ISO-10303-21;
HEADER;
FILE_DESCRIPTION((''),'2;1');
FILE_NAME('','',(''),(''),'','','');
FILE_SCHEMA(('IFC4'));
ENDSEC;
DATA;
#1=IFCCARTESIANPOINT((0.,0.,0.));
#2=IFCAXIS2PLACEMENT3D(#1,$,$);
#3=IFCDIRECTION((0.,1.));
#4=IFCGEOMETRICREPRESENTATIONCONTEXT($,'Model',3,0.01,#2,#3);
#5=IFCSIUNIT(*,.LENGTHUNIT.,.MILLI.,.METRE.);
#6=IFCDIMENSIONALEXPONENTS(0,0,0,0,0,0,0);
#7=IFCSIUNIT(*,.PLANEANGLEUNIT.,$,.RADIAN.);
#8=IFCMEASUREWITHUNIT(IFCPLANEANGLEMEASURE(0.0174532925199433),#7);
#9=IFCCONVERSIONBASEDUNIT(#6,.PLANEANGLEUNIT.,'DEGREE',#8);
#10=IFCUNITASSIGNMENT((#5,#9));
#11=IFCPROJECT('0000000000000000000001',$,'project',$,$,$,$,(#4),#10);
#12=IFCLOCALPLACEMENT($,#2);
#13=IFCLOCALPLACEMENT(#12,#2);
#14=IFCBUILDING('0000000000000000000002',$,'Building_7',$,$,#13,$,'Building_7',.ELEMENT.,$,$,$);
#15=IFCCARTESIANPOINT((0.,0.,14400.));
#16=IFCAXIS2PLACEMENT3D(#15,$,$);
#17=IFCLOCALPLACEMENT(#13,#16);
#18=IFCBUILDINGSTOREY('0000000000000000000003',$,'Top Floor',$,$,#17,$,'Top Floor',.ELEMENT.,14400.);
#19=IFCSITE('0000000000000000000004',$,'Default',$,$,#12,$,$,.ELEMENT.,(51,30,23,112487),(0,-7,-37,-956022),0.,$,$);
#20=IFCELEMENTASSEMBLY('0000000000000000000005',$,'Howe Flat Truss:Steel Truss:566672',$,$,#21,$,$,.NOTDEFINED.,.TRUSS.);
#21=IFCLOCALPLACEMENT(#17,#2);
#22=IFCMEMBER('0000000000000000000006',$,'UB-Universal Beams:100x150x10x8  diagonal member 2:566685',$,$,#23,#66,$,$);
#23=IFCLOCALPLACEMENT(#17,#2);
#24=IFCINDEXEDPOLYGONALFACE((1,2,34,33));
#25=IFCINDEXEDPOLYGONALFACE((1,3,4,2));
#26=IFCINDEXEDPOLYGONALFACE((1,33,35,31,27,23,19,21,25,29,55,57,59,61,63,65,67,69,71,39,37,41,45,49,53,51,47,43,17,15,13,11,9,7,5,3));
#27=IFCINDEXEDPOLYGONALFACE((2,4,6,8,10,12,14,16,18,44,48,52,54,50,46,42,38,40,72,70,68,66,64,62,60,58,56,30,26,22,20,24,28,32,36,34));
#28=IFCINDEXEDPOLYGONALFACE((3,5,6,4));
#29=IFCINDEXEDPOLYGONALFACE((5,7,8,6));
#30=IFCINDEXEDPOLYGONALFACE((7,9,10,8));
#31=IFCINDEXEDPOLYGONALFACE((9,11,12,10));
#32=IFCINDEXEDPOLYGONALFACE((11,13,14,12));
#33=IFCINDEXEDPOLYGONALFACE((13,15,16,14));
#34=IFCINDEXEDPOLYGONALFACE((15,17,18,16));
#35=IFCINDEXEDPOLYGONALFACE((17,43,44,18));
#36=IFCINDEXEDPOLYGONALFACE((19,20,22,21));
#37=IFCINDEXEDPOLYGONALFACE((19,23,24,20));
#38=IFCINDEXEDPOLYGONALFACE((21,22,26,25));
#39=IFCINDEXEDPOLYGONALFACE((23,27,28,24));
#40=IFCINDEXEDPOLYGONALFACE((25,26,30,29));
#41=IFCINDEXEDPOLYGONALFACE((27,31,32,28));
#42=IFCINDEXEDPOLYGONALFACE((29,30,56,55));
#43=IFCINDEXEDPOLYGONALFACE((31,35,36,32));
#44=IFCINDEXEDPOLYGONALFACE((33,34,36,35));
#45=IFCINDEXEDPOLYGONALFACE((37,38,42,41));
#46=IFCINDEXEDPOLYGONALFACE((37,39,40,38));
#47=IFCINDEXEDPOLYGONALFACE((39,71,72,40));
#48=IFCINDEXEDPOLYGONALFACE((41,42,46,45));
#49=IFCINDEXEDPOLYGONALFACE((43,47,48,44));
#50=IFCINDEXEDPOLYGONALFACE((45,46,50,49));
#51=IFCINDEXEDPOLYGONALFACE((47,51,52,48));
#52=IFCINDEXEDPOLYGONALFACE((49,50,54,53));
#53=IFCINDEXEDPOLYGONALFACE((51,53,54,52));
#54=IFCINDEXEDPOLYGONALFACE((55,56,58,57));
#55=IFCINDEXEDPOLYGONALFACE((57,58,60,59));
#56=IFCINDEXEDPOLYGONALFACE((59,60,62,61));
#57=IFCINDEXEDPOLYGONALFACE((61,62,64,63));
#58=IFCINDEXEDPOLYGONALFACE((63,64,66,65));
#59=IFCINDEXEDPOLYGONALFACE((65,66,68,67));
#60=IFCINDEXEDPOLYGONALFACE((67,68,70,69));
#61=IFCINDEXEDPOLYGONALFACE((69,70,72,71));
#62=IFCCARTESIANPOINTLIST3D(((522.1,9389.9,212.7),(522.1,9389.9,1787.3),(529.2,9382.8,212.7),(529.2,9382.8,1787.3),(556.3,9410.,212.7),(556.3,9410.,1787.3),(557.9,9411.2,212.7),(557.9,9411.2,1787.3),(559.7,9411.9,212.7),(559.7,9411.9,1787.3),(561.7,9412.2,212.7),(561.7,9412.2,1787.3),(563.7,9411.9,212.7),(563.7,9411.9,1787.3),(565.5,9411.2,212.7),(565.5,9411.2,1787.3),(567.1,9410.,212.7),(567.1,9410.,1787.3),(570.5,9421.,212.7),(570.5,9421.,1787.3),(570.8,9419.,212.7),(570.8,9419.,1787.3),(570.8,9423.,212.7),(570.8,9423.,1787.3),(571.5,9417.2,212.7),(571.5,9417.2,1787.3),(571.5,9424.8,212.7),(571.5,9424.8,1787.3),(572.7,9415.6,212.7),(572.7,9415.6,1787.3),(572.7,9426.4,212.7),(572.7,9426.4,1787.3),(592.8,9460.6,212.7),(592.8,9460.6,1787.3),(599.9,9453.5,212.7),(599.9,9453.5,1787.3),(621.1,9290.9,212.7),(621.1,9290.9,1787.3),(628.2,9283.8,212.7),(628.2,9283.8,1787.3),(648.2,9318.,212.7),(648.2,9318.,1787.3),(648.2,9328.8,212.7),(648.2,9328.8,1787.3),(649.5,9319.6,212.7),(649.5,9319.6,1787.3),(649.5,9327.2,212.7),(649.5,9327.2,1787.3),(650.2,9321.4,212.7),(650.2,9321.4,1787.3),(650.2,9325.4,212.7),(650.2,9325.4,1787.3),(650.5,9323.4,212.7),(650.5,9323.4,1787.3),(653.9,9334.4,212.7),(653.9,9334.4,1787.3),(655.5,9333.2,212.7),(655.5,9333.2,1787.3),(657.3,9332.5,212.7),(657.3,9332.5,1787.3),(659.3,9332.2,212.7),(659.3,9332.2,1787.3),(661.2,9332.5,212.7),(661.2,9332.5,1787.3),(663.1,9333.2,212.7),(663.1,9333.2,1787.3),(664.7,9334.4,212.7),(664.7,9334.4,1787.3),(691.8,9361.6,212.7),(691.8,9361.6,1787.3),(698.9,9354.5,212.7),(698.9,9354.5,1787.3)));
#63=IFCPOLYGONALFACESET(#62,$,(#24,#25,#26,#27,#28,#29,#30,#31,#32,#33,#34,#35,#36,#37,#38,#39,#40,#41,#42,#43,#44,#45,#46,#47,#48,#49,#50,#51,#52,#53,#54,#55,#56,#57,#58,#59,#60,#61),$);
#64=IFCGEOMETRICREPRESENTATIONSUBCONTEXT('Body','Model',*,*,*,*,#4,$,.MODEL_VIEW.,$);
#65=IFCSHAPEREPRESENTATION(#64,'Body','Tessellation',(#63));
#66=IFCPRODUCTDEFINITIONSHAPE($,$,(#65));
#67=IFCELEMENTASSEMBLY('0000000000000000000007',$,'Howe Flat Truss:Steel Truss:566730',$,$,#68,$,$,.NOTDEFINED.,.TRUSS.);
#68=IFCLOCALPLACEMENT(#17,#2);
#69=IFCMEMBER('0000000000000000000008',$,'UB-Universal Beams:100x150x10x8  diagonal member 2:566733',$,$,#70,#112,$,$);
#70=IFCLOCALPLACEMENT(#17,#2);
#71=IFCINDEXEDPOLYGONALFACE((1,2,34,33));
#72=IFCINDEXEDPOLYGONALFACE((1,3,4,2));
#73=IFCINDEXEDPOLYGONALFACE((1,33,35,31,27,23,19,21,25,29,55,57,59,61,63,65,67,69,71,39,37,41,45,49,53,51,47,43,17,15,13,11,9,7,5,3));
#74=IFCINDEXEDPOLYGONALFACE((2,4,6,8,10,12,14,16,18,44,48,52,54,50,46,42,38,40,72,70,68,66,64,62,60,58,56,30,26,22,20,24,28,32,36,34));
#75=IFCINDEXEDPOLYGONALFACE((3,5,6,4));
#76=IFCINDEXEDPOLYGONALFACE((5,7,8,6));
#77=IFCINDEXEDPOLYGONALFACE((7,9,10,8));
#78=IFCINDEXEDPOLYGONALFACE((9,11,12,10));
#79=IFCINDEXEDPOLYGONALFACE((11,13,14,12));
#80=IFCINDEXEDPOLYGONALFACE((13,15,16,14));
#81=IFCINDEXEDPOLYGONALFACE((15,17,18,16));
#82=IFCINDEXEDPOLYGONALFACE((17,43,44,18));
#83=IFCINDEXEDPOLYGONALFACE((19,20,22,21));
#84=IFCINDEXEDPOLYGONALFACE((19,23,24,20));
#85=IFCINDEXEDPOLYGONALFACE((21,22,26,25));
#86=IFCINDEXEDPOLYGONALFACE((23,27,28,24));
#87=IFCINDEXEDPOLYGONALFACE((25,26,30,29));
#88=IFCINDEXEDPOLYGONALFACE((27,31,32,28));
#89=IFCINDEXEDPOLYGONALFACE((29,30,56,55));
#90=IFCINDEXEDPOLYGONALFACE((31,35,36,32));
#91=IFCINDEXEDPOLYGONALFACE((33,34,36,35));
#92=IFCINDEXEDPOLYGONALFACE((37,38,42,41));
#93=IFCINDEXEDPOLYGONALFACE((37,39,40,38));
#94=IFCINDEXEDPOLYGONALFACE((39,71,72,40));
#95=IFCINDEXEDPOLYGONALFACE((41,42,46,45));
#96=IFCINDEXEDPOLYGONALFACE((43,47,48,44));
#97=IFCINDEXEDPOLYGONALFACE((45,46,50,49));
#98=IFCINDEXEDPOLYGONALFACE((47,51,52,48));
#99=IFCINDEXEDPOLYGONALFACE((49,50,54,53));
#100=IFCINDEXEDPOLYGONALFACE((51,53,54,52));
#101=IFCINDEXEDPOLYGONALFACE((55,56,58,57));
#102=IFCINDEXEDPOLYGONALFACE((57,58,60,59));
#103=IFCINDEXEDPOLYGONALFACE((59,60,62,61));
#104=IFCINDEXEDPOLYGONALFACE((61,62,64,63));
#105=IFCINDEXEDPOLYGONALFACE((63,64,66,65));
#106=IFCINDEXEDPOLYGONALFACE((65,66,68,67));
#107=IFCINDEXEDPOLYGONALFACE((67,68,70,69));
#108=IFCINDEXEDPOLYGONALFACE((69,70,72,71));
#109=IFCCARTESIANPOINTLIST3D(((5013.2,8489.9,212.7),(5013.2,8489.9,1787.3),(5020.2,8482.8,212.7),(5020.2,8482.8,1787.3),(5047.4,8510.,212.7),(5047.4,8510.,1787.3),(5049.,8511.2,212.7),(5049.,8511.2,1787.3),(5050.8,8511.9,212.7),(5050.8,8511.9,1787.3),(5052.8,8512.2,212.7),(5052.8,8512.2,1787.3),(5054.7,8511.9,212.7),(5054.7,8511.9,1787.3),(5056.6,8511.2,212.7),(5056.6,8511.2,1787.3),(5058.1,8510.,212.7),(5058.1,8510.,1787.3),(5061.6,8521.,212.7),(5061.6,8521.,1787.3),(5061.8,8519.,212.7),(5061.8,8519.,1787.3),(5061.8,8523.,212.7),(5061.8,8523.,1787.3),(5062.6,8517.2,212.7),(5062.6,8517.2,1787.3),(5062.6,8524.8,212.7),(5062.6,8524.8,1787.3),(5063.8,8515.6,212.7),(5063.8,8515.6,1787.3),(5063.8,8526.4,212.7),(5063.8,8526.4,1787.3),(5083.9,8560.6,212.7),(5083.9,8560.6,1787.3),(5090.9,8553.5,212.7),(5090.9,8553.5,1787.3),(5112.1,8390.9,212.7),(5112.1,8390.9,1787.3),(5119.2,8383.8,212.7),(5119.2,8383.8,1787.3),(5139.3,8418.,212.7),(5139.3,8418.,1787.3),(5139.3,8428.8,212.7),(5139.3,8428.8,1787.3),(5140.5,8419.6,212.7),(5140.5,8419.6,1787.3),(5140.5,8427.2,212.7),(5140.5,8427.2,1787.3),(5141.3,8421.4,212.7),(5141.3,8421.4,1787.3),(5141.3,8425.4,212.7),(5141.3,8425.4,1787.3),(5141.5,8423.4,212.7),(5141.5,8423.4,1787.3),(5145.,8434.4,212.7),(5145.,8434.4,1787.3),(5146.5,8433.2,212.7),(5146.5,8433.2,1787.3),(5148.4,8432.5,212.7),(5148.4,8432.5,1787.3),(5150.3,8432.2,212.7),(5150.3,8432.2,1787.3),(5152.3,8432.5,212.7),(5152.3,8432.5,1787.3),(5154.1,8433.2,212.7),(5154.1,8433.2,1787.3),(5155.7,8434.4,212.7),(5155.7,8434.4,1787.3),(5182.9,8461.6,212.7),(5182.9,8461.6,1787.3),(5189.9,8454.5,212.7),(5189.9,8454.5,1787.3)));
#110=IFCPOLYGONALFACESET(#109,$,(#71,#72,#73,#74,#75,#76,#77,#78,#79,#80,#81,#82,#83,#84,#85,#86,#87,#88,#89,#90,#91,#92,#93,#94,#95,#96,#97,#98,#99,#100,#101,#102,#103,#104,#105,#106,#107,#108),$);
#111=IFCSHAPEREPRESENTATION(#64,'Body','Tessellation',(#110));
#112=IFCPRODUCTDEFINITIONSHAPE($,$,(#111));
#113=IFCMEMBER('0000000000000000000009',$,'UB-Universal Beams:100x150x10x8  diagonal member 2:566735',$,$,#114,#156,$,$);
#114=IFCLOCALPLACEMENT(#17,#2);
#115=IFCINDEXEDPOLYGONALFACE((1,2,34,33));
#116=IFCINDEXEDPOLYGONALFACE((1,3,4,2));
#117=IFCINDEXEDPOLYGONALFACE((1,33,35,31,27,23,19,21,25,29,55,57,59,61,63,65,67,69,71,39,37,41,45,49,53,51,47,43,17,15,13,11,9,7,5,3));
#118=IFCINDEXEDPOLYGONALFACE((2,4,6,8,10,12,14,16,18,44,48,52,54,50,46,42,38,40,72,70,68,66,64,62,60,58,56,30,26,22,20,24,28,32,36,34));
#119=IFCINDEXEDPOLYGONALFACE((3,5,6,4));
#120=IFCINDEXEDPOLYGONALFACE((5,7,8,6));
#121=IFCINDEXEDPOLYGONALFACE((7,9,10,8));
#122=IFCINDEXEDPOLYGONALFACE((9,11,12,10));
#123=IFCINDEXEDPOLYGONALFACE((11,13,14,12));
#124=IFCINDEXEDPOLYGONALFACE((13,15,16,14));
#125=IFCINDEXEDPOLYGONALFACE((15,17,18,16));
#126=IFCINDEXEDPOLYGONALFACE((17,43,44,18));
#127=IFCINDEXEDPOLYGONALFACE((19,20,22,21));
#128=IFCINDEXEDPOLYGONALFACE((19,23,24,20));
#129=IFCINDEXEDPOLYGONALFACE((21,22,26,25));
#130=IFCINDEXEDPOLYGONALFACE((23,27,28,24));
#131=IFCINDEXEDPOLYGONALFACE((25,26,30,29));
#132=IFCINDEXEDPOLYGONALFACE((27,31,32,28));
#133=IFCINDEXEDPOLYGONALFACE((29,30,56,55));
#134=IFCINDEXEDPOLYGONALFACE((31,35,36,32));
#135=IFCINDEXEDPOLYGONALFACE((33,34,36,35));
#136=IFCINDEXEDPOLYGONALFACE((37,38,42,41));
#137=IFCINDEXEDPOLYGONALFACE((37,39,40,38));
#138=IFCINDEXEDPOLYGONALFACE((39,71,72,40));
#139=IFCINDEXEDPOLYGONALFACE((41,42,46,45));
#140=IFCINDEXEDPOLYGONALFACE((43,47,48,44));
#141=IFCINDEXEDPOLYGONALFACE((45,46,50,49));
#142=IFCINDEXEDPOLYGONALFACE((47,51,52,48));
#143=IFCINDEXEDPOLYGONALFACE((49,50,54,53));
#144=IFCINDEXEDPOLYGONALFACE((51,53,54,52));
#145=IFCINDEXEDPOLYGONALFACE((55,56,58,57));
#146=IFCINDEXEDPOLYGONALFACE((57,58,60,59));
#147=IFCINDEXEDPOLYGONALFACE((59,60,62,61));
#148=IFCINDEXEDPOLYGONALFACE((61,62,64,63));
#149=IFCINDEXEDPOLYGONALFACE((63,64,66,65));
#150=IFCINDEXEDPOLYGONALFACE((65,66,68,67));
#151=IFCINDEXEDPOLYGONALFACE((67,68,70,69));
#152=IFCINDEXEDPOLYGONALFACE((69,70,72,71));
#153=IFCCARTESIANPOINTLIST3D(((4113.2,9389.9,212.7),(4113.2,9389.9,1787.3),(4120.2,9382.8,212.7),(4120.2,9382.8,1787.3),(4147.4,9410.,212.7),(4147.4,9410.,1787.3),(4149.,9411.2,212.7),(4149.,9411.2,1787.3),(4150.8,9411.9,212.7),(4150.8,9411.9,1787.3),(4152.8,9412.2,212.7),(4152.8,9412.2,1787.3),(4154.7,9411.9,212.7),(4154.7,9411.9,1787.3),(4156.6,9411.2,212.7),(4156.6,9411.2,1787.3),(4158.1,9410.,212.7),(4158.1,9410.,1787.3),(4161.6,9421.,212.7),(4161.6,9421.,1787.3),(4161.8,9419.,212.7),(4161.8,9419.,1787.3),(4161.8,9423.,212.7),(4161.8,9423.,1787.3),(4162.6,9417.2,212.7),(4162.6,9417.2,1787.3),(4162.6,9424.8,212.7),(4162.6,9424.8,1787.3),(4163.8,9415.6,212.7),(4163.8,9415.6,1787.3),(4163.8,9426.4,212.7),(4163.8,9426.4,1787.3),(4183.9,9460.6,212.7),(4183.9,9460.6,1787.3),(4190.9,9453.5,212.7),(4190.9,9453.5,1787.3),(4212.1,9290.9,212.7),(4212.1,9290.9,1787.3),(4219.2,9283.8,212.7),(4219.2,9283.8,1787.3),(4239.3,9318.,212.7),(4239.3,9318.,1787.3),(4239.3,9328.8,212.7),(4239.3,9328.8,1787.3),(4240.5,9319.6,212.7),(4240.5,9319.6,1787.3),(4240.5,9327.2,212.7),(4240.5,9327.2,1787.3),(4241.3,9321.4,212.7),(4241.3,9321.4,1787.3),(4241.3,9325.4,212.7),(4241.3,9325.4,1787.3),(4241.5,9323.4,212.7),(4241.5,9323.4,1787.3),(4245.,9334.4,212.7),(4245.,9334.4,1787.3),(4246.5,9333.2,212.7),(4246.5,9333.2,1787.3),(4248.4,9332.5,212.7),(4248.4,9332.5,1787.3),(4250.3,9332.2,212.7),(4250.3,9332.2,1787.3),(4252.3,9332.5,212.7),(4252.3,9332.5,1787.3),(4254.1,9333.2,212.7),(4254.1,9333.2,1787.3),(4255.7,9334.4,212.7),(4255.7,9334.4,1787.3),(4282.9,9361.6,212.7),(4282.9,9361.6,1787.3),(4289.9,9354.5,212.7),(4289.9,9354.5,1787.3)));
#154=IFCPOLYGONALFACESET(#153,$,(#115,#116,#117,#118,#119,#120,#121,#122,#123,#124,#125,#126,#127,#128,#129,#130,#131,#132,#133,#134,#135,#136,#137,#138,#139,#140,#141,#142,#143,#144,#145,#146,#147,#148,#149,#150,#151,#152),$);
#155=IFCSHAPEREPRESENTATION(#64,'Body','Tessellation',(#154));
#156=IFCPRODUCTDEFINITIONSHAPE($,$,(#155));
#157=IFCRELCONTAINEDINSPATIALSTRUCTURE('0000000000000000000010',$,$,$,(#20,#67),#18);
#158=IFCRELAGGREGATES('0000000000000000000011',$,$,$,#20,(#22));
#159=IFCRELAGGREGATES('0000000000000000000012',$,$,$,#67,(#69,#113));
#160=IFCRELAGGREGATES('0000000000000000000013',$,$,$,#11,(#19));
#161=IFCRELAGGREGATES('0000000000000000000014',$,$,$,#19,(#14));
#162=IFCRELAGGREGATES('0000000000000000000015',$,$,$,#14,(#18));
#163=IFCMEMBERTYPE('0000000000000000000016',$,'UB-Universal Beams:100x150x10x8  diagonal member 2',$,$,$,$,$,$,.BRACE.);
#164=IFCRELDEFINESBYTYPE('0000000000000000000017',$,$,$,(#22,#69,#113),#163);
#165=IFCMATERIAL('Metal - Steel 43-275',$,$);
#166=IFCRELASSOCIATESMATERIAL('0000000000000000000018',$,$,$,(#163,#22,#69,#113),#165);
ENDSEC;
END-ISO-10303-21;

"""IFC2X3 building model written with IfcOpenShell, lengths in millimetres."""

from ifc_helpers import new_model, entity, si_unit, converted_unit, direction, frame, frame_2d, origin, place, context, subcontext, project, spatial, polyline, circle_curve, parameter, trimmed, segment, composite_curve, outline, extrude, source, transform, mapped, material, type_object, type_shapes, element, aggregate, save


model = new_model("IFC2X3")

# Units and contexts
model_context = context("Model", 3, precision=0.01, world=origin(), true_north=direction((0.0, 1.0)))
body_context = subcontext(model_context, "Body", "Model", "MODEL_VIEW")
ifc_project = project(units=[si_unit("LENGTHUNIT", "METRE", prefix="MILLI"), converted_unit("PLANEANGLEUNIT", "DEGREE", entity("IfcPlaneAngleMeasure", 0.0174532925199433), si_unit("PLANEANGLEUNIT", "RADIAN"), dimensions=[0, 0, 0, 0, 0, 0, 0])], contexts=[model_context])

# Site, building, storey
site_placement = place(None, origin())
site = spatial("IfcSite", under=ifc_project, at=site_placement, Name="Default", CompositionType="ELEMENT", RefLatitude=(51, 30, 23, 112487), RefLongitude=(0, -7, -37, -956022), RefElevation=0.0)
building_placement = place(site_placement, origin())
building = spatial("IfcBuilding", under=site, at=building_placement, Name="Building_7", LongName="Building_7", CompositionType="ELEMENT")
storey_placement = place(building_placement, frame((0.0, 0.0, 14400.0)))
storey = spatial("IfcBuildingStorey", under=building, at=storey_placement, Name="Top Floor", LongName="Top Floor", CompositionType="ELEMENT", Elevation=14400.0)

# Shared definitions
ifc_material = material(Name="Metal - Steel 43-275")

# Element assemblies, members
member_type_1 = type_object("IfcMemberType", Name="UB-Universal Beams:100x150x10x8  diagonal member 2", PredefinedType="BRACE", material=ifc_material)
shared_shape_1 = source(origin(), body_context, "Body", "SweptSolid", [
    extrude(outline(composite_curve([segment(polyline([(-50.0, -65.0), (-50.0, -75.0)]), True, "CONTINUOUS"), segment(polyline([(-50.0, -75.0), (50.0, -75.0)]), True, "CONTINUOUS"), segment(polyline([(50.0, -75.0), (50.0, -65.0)]), True, "CONTINUOUS"), segment(polyline([(50.0, -65.0), (11.6, -65.0)]), True, "CONTINUOUS"), segment(trimmed(circle_curve(frame_2d((11.6, -57.4), x_axis=(1.0, 0.0)), 7.6), [parameter(180.0)], [parameter(270.0)], True, "PARAMETER"), False, "CONTINUOUS"), segment(polyline([(4.0, -57.4), (4.0, 57.4)]), True, "CONTINUOUS"), segment(trimmed(circle_curve(frame_2d((11.6, 57.4), x_axis=(1.0, 0.0)), 7.6), [parameter(90.0)], [parameter(180.0)], True, "PARAMETER"), False, "CONTINUOUS"), segment(polyline([(11.6, 65.0), (50.0, 65.0)]), True, "CONTINUOUS"), segment(polyline([(50.0, 65.0), (50.0, 75.0)]), True, "CONTINUOUS"), segment(polyline([(50.0, 75.0), (-50.0, 75.0)]), True, "CONTINUOUS"), segment(polyline([(-50.0, 75.0), (-50.0, 65.0)]), True, "CONTINUOUS"), segment(polyline([(-50.0, 65.0), (-11.6, 65.0)]), True, "CONTINUOUS"), segment(trimmed(circle_curve(frame_2d((-11.6, 57.4), x_axis=(1.0, 0.0)), 7.6), [parameter(360.0)], [parameter(90.0)], True, "PARAMETER"), False, "CONTINUOUS"), segment(polyline([(-4.0, 57.4), (-4.0, -57.4)]), True, "CONTINUOUS"), segment(trimmed(circle_curve(frame_2d((-11.6, -57.4), x_axis=(1.0, 0.0)), 7.6), [parameter(270.0)], [parameter(360.0)], True, "PARAMETER"), False, "CONTINUOUS"), segment(polyline([(-11.6, -65.0), (-50.0, -65.0)]), True, "CONTINUOUS")], self_intersect=False)), frame((-787.3, 0.0, 0.0), z_axis=(-1.0, 0.0, 0.0), x_axis=(0.0, -1.0, 0.0)), (0.0, 0.0, -1.0), 1574.6),
])
type_shapes(member_type_1, [shared_shape_1])
assembly_1_placement = place(storey_placement, origin())
assembly_1 = element("IfcElementAssembly", 1, at=assembly_1_placement, inside=storey, Name="Howe Flat Truss:Steel Truss:566672", AssemblyPlace="NOTDEFINED", PredefinedType="TRUSS")
member_1_placement = place(assembly_1_placement, frame((610.5, 9372.2, 1000.0), z_axis=(-0.707107, 0.707107, 0.0), x_axis=(0.0, 0.0, 1.0)))
member_1 = element("IfcMember", 2, at=member_1_placement, type_object=member_type_1, material=ifc_material, Name="UB-Universal Beams:100x150x10x8  diagonal member 2:566685", context=body_context, shape_type="MappedRepresentation", body=[
    mapped(shared_shape_1, transform((0.0, 0.0, 0.0), scale=1.0)),
])
assembly_2_placement = place(storey_placement, origin())
assembly_2 = element("IfcElementAssembly", 3, at=assembly_2_placement, inside=storey, Name="Howe Flat Truss:Steel Truss:566730", AssemblyPlace="NOTDEFINED", PredefinedType="TRUSS")
member_2_placement = place(assembly_2_placement, frame((5101.5, 8472.2, 1000.0), z_axis=(0.707107, -0.707107, 0.0), x_axis=(0.0, 0.0, 1.0)))
member_2 = element("IfcMember", 4, at=member_2_placement, type_object=member_type_1, material=ifc_material, Name="UB-Universal Beams:100x150x10x8  diagonal member 2:566733", context=body_context, shape_type="MappedRepresentation", body=[
    mapped(shared_shape_1, transform((0.0, 0.0, 0.0), scale=1.0)),
])
member_3_placement = place(assembly_2_placement, frame((4201.5, 9372.2, 1000.0), z_axis=(0.707107, -0.707107, 0.0), x_axis=(0.0, 0.0, 1.0)))
member_3 = element("IfcMember", 5, at=member_3_placement, type_object=member_type_1, material=ifc_material, Name="UB-Universal Beams:100x150x10x8  diagonal member 2:566735", context=body_context, shape_type="MappedRepresentation", body=[
    mapped(shared_shape_1, transform((0.0, 0.0, 0.0), scale=1.0)),
])

aggregate(assembly_1, [member_1])
aggregate(assembly_2, [member_2, member_3])

save(model, "model.ifc")
